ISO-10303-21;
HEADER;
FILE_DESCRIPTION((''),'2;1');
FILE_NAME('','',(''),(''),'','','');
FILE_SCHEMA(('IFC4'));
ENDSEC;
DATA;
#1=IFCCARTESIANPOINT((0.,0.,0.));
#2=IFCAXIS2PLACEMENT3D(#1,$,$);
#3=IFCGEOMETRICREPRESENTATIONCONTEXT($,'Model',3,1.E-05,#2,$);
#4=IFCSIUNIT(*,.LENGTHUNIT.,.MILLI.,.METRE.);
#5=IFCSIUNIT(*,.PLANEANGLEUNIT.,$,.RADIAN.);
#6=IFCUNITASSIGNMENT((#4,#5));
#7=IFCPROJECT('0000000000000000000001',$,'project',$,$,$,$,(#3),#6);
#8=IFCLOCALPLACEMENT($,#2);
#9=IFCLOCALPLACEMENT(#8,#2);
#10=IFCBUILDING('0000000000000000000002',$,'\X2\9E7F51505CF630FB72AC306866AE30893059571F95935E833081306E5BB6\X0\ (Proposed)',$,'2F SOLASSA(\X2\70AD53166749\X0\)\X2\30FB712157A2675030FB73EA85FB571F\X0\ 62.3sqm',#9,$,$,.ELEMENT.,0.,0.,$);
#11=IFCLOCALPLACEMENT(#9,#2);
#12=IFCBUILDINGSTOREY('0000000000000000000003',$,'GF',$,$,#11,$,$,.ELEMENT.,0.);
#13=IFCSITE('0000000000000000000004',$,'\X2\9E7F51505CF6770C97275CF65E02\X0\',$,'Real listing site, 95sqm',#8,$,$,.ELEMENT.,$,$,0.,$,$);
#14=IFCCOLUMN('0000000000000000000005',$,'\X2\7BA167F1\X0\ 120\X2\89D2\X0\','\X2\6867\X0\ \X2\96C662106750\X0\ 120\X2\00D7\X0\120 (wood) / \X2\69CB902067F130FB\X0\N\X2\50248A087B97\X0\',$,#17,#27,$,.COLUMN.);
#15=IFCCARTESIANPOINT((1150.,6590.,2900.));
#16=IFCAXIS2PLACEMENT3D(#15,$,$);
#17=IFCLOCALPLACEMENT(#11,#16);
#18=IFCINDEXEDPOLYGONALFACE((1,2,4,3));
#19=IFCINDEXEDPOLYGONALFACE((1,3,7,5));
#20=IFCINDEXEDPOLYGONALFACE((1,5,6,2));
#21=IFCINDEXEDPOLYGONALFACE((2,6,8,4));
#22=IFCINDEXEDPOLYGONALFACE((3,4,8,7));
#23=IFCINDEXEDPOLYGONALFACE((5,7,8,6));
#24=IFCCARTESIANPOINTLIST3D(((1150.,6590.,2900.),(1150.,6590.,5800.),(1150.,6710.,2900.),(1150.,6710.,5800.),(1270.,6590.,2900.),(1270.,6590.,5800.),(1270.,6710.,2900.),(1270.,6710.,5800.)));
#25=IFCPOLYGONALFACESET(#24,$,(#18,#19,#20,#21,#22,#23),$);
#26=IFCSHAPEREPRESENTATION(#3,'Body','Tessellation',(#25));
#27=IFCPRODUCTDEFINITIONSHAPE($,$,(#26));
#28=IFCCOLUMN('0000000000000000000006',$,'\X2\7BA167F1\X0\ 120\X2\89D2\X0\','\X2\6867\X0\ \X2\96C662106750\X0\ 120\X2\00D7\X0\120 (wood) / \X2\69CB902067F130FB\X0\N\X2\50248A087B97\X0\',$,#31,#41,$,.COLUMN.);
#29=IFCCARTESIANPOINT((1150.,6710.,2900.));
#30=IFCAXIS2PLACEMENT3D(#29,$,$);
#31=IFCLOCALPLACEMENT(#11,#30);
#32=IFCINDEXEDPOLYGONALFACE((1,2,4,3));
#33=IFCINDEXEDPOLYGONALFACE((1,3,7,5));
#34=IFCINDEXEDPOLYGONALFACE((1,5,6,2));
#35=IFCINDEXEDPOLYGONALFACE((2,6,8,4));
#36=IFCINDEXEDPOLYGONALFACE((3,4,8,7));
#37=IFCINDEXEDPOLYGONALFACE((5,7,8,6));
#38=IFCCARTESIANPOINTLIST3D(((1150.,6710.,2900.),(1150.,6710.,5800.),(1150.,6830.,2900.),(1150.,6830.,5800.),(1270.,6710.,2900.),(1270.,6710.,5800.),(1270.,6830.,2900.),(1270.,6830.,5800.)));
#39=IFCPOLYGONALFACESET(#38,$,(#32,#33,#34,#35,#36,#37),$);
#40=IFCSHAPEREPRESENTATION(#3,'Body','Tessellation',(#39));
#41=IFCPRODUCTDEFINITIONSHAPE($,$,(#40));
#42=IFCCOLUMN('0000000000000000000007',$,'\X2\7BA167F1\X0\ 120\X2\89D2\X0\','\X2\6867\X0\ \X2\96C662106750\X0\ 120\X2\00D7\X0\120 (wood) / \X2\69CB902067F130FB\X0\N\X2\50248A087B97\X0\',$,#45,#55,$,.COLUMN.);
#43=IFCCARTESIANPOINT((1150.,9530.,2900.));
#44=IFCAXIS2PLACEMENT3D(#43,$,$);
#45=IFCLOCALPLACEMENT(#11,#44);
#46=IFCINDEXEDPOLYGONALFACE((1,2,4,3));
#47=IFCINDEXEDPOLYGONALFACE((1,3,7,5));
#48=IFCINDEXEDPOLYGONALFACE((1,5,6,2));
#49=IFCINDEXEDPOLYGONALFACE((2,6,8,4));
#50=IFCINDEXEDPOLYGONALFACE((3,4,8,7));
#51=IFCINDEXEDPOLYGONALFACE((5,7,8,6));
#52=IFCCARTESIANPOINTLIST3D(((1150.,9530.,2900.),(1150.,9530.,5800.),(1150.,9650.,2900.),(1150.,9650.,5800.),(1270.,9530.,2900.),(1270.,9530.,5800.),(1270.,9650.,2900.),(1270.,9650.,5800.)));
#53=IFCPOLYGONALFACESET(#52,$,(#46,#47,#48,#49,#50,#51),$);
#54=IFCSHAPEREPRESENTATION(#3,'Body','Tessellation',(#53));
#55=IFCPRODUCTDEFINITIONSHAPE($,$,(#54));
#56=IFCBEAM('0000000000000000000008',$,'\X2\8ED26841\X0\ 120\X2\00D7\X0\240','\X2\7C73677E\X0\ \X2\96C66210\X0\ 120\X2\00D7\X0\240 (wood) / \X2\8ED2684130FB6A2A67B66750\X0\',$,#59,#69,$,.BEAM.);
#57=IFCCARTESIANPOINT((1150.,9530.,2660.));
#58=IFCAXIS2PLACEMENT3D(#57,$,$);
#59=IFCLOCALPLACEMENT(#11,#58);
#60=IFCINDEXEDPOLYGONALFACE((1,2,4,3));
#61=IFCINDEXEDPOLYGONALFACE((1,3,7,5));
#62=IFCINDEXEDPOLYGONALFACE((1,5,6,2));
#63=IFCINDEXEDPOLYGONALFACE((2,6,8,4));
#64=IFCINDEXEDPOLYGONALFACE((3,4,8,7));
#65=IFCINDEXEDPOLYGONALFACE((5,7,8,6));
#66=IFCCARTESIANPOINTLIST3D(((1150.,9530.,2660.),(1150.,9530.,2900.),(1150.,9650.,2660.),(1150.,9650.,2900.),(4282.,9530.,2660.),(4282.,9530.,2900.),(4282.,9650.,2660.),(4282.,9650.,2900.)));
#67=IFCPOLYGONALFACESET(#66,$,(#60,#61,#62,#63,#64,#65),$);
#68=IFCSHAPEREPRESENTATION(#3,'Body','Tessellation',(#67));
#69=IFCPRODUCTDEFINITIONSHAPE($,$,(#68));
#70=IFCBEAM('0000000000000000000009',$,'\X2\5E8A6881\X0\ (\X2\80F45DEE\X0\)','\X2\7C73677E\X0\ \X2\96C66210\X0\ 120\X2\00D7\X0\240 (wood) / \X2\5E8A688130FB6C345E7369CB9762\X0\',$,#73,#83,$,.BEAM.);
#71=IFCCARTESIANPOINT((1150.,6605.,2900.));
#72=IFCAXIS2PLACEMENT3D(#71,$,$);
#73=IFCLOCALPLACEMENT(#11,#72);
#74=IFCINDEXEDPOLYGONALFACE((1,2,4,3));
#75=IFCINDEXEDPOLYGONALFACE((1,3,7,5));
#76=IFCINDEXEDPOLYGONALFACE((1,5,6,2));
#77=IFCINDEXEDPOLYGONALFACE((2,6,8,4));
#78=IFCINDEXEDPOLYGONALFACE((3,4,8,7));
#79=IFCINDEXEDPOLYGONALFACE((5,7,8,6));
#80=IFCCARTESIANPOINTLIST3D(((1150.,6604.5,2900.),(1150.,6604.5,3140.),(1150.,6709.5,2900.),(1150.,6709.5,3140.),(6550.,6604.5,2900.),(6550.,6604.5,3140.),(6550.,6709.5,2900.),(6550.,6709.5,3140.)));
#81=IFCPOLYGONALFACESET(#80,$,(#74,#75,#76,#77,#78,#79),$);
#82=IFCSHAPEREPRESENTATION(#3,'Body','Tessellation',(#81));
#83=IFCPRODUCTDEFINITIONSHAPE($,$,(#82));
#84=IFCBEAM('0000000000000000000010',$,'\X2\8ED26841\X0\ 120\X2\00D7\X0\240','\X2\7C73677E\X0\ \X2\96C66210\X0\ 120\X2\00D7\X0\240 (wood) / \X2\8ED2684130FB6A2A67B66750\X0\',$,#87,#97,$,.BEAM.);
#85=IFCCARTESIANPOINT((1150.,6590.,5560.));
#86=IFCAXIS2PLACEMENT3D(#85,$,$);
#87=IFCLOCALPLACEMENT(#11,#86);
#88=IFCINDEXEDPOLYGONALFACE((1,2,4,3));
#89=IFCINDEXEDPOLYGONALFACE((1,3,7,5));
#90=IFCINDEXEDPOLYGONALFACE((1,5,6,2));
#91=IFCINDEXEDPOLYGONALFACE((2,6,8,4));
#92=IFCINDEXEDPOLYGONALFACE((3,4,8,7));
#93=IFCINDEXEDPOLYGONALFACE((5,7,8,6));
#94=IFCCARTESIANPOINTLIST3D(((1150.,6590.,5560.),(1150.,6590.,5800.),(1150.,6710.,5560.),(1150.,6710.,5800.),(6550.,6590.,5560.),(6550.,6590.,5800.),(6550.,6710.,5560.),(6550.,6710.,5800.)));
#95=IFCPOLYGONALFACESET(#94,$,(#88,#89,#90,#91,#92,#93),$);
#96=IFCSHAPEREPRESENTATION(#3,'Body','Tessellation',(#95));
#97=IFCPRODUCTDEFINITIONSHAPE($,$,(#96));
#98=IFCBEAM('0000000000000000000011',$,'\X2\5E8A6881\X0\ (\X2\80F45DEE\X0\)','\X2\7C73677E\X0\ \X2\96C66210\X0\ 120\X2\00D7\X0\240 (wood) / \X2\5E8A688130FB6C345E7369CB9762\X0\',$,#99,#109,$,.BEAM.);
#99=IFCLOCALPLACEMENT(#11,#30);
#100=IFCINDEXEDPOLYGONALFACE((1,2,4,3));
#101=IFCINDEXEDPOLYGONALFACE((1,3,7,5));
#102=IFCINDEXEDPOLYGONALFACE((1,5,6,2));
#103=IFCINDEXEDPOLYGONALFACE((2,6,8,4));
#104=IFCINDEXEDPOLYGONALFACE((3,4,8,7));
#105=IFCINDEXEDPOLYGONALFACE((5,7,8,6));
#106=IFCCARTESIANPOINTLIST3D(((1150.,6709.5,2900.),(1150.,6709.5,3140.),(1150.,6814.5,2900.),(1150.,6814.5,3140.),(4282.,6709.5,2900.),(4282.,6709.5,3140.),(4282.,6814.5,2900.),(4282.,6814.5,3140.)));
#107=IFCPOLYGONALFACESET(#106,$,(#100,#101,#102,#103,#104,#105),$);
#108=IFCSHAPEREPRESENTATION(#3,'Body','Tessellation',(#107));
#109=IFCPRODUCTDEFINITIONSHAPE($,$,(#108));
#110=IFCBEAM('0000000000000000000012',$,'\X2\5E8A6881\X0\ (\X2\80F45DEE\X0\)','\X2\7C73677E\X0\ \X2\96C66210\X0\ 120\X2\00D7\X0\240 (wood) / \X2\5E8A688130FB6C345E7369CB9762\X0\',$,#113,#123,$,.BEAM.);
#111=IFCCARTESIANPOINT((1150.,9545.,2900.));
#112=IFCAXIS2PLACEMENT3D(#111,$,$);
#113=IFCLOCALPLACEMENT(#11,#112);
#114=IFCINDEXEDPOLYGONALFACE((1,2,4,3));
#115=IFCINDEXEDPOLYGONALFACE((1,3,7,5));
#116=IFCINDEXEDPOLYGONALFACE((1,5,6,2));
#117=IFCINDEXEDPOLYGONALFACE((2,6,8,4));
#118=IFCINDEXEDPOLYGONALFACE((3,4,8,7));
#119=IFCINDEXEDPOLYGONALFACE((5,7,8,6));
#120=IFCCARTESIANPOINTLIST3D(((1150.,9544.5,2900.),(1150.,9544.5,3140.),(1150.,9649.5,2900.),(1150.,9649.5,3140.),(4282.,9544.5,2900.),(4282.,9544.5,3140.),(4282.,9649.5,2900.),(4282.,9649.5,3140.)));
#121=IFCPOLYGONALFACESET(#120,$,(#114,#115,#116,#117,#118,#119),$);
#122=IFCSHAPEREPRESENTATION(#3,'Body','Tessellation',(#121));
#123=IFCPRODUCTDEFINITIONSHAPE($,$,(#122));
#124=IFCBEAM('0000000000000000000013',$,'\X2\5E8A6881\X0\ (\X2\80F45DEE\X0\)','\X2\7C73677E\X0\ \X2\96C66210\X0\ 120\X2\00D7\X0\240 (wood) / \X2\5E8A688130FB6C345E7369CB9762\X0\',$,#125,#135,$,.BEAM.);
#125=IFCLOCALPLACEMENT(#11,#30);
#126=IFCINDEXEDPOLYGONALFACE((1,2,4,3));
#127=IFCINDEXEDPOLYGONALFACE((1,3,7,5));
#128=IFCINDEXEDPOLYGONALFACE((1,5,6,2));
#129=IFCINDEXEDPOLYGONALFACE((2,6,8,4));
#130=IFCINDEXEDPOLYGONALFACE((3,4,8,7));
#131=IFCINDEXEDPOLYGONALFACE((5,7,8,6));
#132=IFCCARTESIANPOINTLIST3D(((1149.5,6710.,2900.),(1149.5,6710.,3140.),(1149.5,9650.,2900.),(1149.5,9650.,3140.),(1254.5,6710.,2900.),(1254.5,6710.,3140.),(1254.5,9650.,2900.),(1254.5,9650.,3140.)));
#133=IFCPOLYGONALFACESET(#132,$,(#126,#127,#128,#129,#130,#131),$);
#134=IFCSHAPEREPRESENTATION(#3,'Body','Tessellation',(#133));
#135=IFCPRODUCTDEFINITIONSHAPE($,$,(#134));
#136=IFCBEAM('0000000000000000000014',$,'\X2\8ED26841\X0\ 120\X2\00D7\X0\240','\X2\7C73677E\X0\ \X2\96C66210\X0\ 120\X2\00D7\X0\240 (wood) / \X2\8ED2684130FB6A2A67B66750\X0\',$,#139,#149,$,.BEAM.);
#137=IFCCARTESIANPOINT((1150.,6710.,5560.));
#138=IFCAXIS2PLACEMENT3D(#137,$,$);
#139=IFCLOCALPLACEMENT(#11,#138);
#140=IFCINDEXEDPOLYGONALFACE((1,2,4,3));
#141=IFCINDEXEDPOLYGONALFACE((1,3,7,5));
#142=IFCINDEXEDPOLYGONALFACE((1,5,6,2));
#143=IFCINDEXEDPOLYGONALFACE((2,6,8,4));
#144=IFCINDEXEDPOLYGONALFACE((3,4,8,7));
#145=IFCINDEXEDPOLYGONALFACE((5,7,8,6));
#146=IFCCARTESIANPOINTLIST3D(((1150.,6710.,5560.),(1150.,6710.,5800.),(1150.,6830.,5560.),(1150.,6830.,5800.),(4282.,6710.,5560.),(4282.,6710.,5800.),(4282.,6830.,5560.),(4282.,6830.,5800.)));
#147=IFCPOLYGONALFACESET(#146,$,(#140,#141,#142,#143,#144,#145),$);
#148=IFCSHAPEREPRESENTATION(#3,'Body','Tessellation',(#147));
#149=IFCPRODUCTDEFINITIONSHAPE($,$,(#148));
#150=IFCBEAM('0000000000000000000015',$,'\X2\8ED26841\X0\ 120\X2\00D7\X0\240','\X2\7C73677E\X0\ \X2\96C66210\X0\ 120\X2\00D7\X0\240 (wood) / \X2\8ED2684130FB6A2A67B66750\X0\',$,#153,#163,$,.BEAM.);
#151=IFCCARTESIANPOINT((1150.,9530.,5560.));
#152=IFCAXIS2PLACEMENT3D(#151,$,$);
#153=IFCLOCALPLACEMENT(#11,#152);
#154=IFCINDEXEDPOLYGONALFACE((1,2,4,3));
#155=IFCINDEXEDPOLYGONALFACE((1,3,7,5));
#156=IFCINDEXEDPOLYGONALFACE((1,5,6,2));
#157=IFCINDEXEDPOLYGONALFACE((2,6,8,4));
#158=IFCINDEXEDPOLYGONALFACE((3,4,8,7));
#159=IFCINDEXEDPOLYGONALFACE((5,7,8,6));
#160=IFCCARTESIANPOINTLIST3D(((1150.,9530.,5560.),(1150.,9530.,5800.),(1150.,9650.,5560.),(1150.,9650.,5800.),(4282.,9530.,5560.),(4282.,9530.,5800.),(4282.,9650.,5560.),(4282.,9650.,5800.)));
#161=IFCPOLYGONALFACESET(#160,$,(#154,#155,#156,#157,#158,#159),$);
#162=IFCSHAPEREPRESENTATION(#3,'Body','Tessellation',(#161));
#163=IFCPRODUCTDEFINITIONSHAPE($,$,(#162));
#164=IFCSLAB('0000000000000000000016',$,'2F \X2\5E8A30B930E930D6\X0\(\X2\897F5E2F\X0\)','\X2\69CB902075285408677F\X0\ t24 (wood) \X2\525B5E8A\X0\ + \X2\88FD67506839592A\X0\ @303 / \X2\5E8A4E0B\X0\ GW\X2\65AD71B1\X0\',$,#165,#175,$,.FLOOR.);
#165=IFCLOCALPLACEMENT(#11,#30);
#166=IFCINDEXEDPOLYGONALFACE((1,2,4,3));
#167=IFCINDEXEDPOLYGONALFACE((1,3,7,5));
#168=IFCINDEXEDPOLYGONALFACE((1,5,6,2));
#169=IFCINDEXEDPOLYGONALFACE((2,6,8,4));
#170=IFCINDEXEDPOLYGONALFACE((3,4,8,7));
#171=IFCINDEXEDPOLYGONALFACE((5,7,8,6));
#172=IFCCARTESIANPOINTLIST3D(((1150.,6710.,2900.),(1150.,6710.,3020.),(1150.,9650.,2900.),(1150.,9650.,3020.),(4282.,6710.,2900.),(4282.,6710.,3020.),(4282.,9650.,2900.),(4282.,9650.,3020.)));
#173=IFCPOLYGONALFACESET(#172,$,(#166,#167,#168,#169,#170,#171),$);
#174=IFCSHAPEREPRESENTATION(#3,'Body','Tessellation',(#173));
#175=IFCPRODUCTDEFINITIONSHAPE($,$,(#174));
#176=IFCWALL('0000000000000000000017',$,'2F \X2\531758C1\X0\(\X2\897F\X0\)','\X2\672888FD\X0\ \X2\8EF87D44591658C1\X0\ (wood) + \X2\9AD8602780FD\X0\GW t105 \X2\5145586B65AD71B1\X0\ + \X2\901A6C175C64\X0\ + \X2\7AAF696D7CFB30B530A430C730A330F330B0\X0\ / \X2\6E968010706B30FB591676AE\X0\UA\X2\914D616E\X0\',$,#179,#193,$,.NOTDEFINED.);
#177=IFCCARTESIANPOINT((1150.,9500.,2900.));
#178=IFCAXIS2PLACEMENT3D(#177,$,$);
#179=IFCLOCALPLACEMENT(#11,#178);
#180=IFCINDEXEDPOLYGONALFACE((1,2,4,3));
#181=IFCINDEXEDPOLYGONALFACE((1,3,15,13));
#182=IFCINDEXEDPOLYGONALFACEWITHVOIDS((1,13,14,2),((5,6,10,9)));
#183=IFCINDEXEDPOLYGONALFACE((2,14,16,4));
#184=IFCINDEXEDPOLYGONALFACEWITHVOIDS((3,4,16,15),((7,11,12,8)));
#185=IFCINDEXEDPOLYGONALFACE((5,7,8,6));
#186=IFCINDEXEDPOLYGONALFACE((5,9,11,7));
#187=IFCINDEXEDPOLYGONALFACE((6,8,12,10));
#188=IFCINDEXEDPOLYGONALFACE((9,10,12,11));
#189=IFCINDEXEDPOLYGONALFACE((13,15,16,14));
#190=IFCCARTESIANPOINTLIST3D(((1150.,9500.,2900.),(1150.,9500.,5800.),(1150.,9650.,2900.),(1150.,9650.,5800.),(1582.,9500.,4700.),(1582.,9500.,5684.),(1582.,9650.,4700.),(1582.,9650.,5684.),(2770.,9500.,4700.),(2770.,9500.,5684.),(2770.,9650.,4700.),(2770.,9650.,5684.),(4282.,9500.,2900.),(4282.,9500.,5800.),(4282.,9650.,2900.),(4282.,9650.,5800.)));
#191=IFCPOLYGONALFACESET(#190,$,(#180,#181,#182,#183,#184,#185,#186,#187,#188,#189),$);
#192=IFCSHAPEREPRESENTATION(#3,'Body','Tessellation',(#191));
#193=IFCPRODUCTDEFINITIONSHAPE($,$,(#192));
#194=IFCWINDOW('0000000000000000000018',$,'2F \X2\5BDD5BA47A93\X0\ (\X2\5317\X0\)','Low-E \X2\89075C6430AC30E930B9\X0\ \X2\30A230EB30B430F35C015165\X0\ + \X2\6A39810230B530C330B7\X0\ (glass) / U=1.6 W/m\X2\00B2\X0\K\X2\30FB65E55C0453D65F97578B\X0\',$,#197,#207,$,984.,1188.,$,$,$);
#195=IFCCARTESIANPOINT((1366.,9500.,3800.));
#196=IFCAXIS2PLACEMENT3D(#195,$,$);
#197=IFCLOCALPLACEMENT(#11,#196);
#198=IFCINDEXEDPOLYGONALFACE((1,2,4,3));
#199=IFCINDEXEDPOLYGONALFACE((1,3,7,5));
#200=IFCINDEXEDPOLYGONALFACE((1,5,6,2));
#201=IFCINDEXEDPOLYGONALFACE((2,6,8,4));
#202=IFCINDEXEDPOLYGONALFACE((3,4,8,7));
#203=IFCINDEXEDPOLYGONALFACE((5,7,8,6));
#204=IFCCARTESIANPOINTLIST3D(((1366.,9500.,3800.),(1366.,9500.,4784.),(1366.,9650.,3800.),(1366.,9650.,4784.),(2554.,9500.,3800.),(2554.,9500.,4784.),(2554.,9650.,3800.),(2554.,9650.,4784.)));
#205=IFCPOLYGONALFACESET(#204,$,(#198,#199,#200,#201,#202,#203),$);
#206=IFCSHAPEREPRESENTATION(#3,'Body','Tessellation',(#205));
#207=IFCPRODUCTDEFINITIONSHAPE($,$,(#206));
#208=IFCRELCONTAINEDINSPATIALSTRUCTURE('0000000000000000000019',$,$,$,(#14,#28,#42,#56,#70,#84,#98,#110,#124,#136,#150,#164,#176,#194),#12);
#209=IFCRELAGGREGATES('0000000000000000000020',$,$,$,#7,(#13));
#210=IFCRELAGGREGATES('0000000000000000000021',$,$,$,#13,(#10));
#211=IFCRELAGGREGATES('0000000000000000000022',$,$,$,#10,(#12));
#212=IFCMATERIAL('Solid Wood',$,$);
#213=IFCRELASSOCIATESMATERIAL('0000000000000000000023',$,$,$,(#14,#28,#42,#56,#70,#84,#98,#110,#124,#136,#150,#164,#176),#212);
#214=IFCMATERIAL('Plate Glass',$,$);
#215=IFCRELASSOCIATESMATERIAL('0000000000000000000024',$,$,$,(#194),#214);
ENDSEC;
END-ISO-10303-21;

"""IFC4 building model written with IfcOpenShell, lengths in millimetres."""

from ifc_helpers import new_model, si_unit, frame, frame_2d, origin, place, context, project, spatial, rectangle, extrude, material, element, fill, save


model = new_model("IFC4")

# Units and contexts
model_context = context("Model", 3, precision=1e-05, world=origin())
ifc_project = project(units=[si_unit("LENGTHUNIT", "METRE", prefix="MILLI"), si_unit("PLANEANGLEUNIT", "RADIAN")], contexts=[model_context])

# Site, building, storey
site_placement = place(None, origin())
site = spatial("IfcSite", under=ifc_project, at=site_placement, Name="鹿児島県霧島市", ObjectType="Real listing site, 95sqm", CompositionType="ELEMENT", RefElevation=0.0)
building_placement = place(site_placement, origin())
building = spatial("IfcBuilding", under=site, at=building_placement, Name="鹿児島・犬と暮らす土間広めの家 (Proposed)", ObjectType="2F SOLASSA(炭化杉)・無垢材・珪藻土 62.3sqm", CompositionType="ELEMENT", ElevationOfRefHeight=0.0, ElevationOfTerrain=0.0)
storey_placement = place(building_placement, origin())
storey = spatial("IfcBuildingStorey", under=building, at=storey_placement, Name="GF", CompositionType="ELEMENT", Elevation=0.0)

# Columns
ifc_material_1 = material(Name="Solid Wood")
column_1_placement = place(storey_placement, frame((1150.0, 6590.0, 2900.0)))
element("IfcColumn", 1, at=column_1_placement, inside=storey, material=ifc_material_1, Name="管柱 120角", Description="桧 集成材 120×120 (wood) / 構造柱・N値計算", PredefinedType="COLUMN", context=model_context, shape_type="SweptSolid", body=[
    extrude(rectangle(XDim=120.0, YDim=120.0, at=frame_2d((60.0, 60.0))), frame((1150.0, 6590.0, 2900.0)), (0.0, 0.0, 1.0), 2900.0),
])
column_2_placement = place(storey_placement, frame((1150.0, 6710.0, 2900.0)))
element("IfcColumn", 2, at=column_2_placement, inside=storey, material=ifc_material_1, Name="管柱 120角", Description="桧 集成材 120×120 (wood) / 構造柱・N値計算", PredefinedType="COLUMN", context=model_context, shape_type="SweptSolid", body=[
    extrude(rectangle(XDim=120.0, YDim=120.0, at=frame_2d((60.0, 60.0))), frame((1150.0, 6710.0, 2900.0)), (0.0, 0.0, 1.0), 2900.0),
])
column_3_placement = place(storey_placement, frame((1150.0, 9530.0, 2900.0)))
element("IfcColumn", 3, at=column_3_placement, inside=storey, material=ifc_material_1, Name="管柱 120角", Description="桧 集成材 120×120 (wood) / 構造柱・N値計算", PredefinedType="COLUMN", context=model_context, shape_type="SweptSolid", body=[
    extrude(rectangle(XDim=120.0, YDim=120.0, at=frame_2d((60.0, 60.0))), frame((1150.0, 9530.0, 2900.0)), (0.0, 0.0, 1.0), 2900.0),
])

# Beams
beam_1_placement = place(storey_placement, frame((1150.0, 9530.0, 2660.0)))
element("IfcBeam", 4, at=beam_1_placement, inside=storey, material=ifc_material_1, Name="軒桁 120×240", Description="米松 集成 120×240 (wood) / 軒桁・横架材", PredefinedType="BEAM", context=model_context, shape_type="SweptSolid", body=[
    extrude(rectangle(XDim=3132.0, YDim=120.0, at=frame_2d((1566.0, 60.0))), frame((1150.0, 9530.0, 2660.0)), (0.0, 0.0, 1.0), 240.0),
])
beam_2_placement = place(storey_placement, frame((1150.0, 6605.0, 2900.0)))
element("IfcBeam", 5, at=beam_2_placement, inside=storey, material=ifc_material_1, Name="床梁 (胴差)", Description="米松 集成 120×240 (wood) / 床梁・水平構面", PredefinedType="BEAM", context=model_context, shape_type="SweptSolid", body=[
    extrude(rectangle(XDim=5400.0, YDim=105.0, at=frame_2d((2700.0, 52.0))), frame((1150.0, 6605.0, 2900.0)), (0.0, 0.0, 1.0), 240.0),
])
beam_3_placement = place(storey_placement, frame((1150.0, 6590.0, 5560.0)))
element("IfcBeam", 6, at=beam_3_placement, inside=storey, material=ifc_material_1, Name="軒桁 120×240", Description="米松 集成 120×240 (wood) / 軒桁・横架材", PredefinedType="BEAM", context=model_context, shape_type="SweptSolid", body=[
    extrude(rectangle(XDim=5400.0, YDim=120.0, at=frame_2d((2700.0, 60.0))), frame((1150.0, 6590.0, 5560.0)), (0.0, 0.0, 1.0), 240.0),
])
beam_4_placement = place(storey_placement, frame((1150.0, 6710.0, 2900.0)))
element("IfcBeam", 7, at=beam_4_placement, inside=storey, material=ifc_material_1, Name="床梁 (胴差)", Description="米松 集成 120×240 (wood) / 床梁・水平構面", PredefinedType="BEAM", context=model_context, shape_type="SweptSolid", body=[
    extrude(rectangle(XDim=3132.0, YDim=105.0, at=frame_2d((1566.0, 52.0))), frame((1150.0, 6710.0, 2900.0)), (0.0, 0.0, 1.0), 240.0),
])
beam_5_placement = place(storey_placement, frame((1150.0, 9545.0, 2900.0)))
element("IfcBeam", 8, at=beam_5_placement, inside=storey, material=ifc_material_1, Name="床梁 (胴差)", Description="米松 集成 120×240 (wood) / 床梁・水平構面", PredefinedType="BEAM", context=model_context, shape_type="SweptSolid", body=[
    extrude(rectangle(XDim=3132.0, YDim=105.0, at=frame_2d((1566.0, 52.0))), frame((1150.0, 9545.0, 2900.0)), (0.0, 0.0, 1.0), 240.0),
])
beam_6_placement = place(storey_placement, frame((1150.0, 6710.0, 2900.0)))
element("IfcBeam", 9, at=beam_6_placement, inside=storey, material=ifc_material_1, Name="床梁 (胴差)", Description="米松 集成 120×240 (wood) / 床梁・水平構面", PredefinedType="BEAM", context=model_context, shape_type="SweptSolid", body=[
    extrude(rectangle(XDim=105.0, YDim=2940.0, at=frame_2d((52.0, 1470.0))), frame((1150.0, 6710.0, 2900.0)), (0.0, 0.0, 1.0), 240.0),
])
beam_7_placement = place(storey_placement, frame((1150.0, 6710.0, 5560.0)))
element("IfcBeam", 10, at=beam_7_placement, inside=storey, material=ifc_material_1, Name="軒桁 120×240", Description="米松 集成 120×240 (wood) / 軒桁・横架材", PredefinedType="BEAM", context=model_context, shape_type="SweptSolid", body=[
    extrude(rectangle(XDim=3132.0, YDim=120.0, at=frame_2d((1566.0, 60.0))), frame((1150.0, 6710.0, 5560.0)), (0.0, 0.0, 1.0), 240.0),
])
beam_8_placement = place(storey_placement, frame((1150.0, 9530.0, 5560.0)))
element("IfcBeam", 11, at=beam_8_placement, inside=storey, material=ifc_material_1, Name="軒桁 120×240", Description="米松 集成 120×240 (wood) / 軒桁・横架材", PredefinedType="BEAM", context=model_context, shape_type="SweptSolid", body=[
    extrude(rectangle(XDim=3132.0, YDim=120.0, at=frame_2d((1566.0, 60.0))), frame((1150.0, 9530.0, 5560.0)), (0.0, 0.0, 1.0), 240.0),
])

# Slab
slab_placement = place(storey_placement, frame((1150.0, 6710.0, 2900.0)))
element("IfcSlab", 12, at=slab_placement, inside=storey, material=ifc_material_1, Name="2F 床スラブ(西帯)", Description="構造用合板 t24 (wood) 剛床 + 製材根太 @303 / 床下 GW断熱", PredefinedType="FLOOR", context=model_context, shape_type="SweptSolid", body=[
    extrude(rectangle(XDim=3132.0, YDim=2940.0, at=frame_2d((1566.0, 1470.0))), frame((1150.0, 6710.0, 2900.0)), (0.0, 0.0, 1.0), 120.0),
])

# Wall, opening, window
wall_1_placement = place(storey_placement, frame((1150.0, 9500.0, 2900.0)))
wall_1 = element("IfcWall", 13, at=wall_1_placement, inside=storey, material=ifc_material_1, Name="2F 北壁(西)", Description="木製 軸組外壁 (wood) + 高性能GW t105 充填断熱 + 通気層 + 窯業系サイディング / 準耐火・外皮UA配慮", PredefinedType="NOTDEFINED", context=model_context, shape_type="SweptSolid", body=[
    extrude(rectangle(XDim=3132.0, YDim=150.0, at=frame_2d((1566.0, 75.0))), frame((1150.0, 9500.0, 2900.0)), (0.0, 0.0, 1.0), 2900.0),
])
opening_placement = place(storey_placement, frame((1366.0, 9500.0, 3800.0)))
opening = element("IfcOpeningElement", 14, at=opening_placement, cuts=wall_1, PredefinedType="NOTDEFINED", context=model_context, shape_type="SweptSolid", body=[
    extrude(rectangle(XDim=1188.0, YDim=150.0, at=frame_2d((594.0, 75.0))), frame((1366.0, 9500.0, 3800.0)), (0.0, 0.0, 1.0), 984.0),
])
ifc_material_2 = material(Name="Plate Glass")
window_placement = place(storey_placement, frame((1366.0, 9500.0, 3800.0)))
window = element("IfcWindow", 15, at=window_placement, inside=storey, material=ifc_material_2, Name="2F 寝室窓 (北)", Description="Low-E 複層ガラス アルゴン封入 + 樹脂サッシ (glass) / U=1.6 W/m²K・日射取得型", OverallHeight=984.0, OverallWidth=1188.0, context=model_context, shape_type="SweptSolid", body=[
    extrude(rectangle(XDim=1188.0, YDim=150.0, at=frame_2d((594.0, 75.0))), frame((1366.0, 9500.0, 3800.0)), (0.0, 0.0, 1.0), 984.0),
])
fill(opening, window)

save(model, "model.ifc")
